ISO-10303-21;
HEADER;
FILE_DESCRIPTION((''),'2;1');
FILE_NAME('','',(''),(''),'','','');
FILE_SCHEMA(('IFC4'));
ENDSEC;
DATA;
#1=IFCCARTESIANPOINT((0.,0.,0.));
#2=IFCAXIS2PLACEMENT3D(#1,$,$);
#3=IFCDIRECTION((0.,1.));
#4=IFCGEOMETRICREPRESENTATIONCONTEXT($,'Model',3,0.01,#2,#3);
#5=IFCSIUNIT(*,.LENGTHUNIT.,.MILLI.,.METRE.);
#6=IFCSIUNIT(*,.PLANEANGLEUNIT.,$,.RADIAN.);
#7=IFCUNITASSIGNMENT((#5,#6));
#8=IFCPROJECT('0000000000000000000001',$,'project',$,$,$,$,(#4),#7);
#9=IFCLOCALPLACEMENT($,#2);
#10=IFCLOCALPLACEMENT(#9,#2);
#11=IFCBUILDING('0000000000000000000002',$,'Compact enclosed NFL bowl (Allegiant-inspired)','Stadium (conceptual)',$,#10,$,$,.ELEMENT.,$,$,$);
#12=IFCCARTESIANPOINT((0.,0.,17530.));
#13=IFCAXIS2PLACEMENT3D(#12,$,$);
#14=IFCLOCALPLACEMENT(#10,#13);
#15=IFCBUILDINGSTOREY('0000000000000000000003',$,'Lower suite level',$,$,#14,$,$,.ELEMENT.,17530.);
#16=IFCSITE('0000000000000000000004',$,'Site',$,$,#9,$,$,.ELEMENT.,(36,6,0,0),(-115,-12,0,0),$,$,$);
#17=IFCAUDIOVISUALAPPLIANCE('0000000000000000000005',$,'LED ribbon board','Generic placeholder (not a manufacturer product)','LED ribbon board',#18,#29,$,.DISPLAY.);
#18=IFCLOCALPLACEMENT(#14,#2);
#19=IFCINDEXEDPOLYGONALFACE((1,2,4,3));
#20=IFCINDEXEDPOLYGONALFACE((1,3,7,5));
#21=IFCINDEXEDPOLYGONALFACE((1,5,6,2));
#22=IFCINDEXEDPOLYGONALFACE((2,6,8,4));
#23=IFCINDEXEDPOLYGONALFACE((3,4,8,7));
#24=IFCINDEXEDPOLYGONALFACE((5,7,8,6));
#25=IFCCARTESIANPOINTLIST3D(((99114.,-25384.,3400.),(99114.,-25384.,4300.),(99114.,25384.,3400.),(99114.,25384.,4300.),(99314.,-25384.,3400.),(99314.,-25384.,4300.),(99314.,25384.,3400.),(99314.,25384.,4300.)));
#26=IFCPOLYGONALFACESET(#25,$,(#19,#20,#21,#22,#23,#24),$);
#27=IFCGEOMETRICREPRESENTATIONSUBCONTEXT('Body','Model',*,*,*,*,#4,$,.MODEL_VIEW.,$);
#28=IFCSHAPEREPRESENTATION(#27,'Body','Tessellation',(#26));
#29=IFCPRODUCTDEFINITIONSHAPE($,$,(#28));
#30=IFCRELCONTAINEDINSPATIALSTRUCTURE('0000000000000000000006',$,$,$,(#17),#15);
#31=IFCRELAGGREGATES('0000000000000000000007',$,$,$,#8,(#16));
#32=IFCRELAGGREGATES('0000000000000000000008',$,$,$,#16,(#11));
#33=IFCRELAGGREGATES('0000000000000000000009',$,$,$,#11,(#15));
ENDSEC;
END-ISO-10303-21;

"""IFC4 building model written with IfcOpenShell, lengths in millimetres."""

from ifc_helpers import new_model, si_unit, direction, frame, origin, place, context, subcontext, project, spatial, line, indexed_curve, outline, extrude, element, save


model = new_model("IFC4")

# Units and contexts
model_context = context("Model", 3, precision=0.01, world=origin(), true_north=direction((0.0, 1.0)))
body_context = subcontext(model_context, "Body", "Model", "MODEL_VIEW")
ifc_project = project(units=[si_unit("LENGTHUNIT", "METRE", prefix="MILLI"), si_unit("PLANEANGLEUNIT", "RADIAN")], contexts=[model_context])

# Site, building, storey
site_placement = place(None, origin())
site = spatial("IfcSite", under=ifc_project, at=site_placement, Name="Site", CompositionType="ELEMENT", RefLatitude=(36, 6, 0, 0), RefLongitude=(-115, -12, 0, 0))
building_placement = place(site_placement, origin())
building = spatial("IfcBuilding", under=site, at=building_placement, Name="Compact enclosed NFL bowl (Allegiant-inspired)", Description="Stadium (conceptual)", CompositionType="ELEMENT")
storey_placement = place(building_placement, frame((0.0, 0.0, 17530.0)))
storey = spatial("IfcBuildingStorey", under=building, at=storey_placement, Name="Lower suite level", CompositionType="ELEMENT", Elevation=17530.0)

# Shared definitions
placement = place(storey_placement, frame((0.0, 0.0, -17530.0)))

# Audio visual appliance
element("IfcAudioVisualAppliance", 1, at=placement, inside=storey, Name="LED ribbon board", Description="Generic placeholder (not a manufacturer product)", ObjectType="LED ribbon board", PredefinedType="DISPLAY", context=body_context, shape_type="SweptSolid", body=[
    extrude(outline(indexed_curve([(99114.0, -25384.0), (99114.0, 25384.0), (99314.0, 25384.0), (99314.0, -25384.0)], segments=[line(1, 2), line(2, 3), line(3, 4), line(4, 1)], self_intersect=False)), frame((0.0, 0.0, 20930.0)), (0.0, 0.0, 1.0), 900.0),
])

save(model, "model.ifc")
